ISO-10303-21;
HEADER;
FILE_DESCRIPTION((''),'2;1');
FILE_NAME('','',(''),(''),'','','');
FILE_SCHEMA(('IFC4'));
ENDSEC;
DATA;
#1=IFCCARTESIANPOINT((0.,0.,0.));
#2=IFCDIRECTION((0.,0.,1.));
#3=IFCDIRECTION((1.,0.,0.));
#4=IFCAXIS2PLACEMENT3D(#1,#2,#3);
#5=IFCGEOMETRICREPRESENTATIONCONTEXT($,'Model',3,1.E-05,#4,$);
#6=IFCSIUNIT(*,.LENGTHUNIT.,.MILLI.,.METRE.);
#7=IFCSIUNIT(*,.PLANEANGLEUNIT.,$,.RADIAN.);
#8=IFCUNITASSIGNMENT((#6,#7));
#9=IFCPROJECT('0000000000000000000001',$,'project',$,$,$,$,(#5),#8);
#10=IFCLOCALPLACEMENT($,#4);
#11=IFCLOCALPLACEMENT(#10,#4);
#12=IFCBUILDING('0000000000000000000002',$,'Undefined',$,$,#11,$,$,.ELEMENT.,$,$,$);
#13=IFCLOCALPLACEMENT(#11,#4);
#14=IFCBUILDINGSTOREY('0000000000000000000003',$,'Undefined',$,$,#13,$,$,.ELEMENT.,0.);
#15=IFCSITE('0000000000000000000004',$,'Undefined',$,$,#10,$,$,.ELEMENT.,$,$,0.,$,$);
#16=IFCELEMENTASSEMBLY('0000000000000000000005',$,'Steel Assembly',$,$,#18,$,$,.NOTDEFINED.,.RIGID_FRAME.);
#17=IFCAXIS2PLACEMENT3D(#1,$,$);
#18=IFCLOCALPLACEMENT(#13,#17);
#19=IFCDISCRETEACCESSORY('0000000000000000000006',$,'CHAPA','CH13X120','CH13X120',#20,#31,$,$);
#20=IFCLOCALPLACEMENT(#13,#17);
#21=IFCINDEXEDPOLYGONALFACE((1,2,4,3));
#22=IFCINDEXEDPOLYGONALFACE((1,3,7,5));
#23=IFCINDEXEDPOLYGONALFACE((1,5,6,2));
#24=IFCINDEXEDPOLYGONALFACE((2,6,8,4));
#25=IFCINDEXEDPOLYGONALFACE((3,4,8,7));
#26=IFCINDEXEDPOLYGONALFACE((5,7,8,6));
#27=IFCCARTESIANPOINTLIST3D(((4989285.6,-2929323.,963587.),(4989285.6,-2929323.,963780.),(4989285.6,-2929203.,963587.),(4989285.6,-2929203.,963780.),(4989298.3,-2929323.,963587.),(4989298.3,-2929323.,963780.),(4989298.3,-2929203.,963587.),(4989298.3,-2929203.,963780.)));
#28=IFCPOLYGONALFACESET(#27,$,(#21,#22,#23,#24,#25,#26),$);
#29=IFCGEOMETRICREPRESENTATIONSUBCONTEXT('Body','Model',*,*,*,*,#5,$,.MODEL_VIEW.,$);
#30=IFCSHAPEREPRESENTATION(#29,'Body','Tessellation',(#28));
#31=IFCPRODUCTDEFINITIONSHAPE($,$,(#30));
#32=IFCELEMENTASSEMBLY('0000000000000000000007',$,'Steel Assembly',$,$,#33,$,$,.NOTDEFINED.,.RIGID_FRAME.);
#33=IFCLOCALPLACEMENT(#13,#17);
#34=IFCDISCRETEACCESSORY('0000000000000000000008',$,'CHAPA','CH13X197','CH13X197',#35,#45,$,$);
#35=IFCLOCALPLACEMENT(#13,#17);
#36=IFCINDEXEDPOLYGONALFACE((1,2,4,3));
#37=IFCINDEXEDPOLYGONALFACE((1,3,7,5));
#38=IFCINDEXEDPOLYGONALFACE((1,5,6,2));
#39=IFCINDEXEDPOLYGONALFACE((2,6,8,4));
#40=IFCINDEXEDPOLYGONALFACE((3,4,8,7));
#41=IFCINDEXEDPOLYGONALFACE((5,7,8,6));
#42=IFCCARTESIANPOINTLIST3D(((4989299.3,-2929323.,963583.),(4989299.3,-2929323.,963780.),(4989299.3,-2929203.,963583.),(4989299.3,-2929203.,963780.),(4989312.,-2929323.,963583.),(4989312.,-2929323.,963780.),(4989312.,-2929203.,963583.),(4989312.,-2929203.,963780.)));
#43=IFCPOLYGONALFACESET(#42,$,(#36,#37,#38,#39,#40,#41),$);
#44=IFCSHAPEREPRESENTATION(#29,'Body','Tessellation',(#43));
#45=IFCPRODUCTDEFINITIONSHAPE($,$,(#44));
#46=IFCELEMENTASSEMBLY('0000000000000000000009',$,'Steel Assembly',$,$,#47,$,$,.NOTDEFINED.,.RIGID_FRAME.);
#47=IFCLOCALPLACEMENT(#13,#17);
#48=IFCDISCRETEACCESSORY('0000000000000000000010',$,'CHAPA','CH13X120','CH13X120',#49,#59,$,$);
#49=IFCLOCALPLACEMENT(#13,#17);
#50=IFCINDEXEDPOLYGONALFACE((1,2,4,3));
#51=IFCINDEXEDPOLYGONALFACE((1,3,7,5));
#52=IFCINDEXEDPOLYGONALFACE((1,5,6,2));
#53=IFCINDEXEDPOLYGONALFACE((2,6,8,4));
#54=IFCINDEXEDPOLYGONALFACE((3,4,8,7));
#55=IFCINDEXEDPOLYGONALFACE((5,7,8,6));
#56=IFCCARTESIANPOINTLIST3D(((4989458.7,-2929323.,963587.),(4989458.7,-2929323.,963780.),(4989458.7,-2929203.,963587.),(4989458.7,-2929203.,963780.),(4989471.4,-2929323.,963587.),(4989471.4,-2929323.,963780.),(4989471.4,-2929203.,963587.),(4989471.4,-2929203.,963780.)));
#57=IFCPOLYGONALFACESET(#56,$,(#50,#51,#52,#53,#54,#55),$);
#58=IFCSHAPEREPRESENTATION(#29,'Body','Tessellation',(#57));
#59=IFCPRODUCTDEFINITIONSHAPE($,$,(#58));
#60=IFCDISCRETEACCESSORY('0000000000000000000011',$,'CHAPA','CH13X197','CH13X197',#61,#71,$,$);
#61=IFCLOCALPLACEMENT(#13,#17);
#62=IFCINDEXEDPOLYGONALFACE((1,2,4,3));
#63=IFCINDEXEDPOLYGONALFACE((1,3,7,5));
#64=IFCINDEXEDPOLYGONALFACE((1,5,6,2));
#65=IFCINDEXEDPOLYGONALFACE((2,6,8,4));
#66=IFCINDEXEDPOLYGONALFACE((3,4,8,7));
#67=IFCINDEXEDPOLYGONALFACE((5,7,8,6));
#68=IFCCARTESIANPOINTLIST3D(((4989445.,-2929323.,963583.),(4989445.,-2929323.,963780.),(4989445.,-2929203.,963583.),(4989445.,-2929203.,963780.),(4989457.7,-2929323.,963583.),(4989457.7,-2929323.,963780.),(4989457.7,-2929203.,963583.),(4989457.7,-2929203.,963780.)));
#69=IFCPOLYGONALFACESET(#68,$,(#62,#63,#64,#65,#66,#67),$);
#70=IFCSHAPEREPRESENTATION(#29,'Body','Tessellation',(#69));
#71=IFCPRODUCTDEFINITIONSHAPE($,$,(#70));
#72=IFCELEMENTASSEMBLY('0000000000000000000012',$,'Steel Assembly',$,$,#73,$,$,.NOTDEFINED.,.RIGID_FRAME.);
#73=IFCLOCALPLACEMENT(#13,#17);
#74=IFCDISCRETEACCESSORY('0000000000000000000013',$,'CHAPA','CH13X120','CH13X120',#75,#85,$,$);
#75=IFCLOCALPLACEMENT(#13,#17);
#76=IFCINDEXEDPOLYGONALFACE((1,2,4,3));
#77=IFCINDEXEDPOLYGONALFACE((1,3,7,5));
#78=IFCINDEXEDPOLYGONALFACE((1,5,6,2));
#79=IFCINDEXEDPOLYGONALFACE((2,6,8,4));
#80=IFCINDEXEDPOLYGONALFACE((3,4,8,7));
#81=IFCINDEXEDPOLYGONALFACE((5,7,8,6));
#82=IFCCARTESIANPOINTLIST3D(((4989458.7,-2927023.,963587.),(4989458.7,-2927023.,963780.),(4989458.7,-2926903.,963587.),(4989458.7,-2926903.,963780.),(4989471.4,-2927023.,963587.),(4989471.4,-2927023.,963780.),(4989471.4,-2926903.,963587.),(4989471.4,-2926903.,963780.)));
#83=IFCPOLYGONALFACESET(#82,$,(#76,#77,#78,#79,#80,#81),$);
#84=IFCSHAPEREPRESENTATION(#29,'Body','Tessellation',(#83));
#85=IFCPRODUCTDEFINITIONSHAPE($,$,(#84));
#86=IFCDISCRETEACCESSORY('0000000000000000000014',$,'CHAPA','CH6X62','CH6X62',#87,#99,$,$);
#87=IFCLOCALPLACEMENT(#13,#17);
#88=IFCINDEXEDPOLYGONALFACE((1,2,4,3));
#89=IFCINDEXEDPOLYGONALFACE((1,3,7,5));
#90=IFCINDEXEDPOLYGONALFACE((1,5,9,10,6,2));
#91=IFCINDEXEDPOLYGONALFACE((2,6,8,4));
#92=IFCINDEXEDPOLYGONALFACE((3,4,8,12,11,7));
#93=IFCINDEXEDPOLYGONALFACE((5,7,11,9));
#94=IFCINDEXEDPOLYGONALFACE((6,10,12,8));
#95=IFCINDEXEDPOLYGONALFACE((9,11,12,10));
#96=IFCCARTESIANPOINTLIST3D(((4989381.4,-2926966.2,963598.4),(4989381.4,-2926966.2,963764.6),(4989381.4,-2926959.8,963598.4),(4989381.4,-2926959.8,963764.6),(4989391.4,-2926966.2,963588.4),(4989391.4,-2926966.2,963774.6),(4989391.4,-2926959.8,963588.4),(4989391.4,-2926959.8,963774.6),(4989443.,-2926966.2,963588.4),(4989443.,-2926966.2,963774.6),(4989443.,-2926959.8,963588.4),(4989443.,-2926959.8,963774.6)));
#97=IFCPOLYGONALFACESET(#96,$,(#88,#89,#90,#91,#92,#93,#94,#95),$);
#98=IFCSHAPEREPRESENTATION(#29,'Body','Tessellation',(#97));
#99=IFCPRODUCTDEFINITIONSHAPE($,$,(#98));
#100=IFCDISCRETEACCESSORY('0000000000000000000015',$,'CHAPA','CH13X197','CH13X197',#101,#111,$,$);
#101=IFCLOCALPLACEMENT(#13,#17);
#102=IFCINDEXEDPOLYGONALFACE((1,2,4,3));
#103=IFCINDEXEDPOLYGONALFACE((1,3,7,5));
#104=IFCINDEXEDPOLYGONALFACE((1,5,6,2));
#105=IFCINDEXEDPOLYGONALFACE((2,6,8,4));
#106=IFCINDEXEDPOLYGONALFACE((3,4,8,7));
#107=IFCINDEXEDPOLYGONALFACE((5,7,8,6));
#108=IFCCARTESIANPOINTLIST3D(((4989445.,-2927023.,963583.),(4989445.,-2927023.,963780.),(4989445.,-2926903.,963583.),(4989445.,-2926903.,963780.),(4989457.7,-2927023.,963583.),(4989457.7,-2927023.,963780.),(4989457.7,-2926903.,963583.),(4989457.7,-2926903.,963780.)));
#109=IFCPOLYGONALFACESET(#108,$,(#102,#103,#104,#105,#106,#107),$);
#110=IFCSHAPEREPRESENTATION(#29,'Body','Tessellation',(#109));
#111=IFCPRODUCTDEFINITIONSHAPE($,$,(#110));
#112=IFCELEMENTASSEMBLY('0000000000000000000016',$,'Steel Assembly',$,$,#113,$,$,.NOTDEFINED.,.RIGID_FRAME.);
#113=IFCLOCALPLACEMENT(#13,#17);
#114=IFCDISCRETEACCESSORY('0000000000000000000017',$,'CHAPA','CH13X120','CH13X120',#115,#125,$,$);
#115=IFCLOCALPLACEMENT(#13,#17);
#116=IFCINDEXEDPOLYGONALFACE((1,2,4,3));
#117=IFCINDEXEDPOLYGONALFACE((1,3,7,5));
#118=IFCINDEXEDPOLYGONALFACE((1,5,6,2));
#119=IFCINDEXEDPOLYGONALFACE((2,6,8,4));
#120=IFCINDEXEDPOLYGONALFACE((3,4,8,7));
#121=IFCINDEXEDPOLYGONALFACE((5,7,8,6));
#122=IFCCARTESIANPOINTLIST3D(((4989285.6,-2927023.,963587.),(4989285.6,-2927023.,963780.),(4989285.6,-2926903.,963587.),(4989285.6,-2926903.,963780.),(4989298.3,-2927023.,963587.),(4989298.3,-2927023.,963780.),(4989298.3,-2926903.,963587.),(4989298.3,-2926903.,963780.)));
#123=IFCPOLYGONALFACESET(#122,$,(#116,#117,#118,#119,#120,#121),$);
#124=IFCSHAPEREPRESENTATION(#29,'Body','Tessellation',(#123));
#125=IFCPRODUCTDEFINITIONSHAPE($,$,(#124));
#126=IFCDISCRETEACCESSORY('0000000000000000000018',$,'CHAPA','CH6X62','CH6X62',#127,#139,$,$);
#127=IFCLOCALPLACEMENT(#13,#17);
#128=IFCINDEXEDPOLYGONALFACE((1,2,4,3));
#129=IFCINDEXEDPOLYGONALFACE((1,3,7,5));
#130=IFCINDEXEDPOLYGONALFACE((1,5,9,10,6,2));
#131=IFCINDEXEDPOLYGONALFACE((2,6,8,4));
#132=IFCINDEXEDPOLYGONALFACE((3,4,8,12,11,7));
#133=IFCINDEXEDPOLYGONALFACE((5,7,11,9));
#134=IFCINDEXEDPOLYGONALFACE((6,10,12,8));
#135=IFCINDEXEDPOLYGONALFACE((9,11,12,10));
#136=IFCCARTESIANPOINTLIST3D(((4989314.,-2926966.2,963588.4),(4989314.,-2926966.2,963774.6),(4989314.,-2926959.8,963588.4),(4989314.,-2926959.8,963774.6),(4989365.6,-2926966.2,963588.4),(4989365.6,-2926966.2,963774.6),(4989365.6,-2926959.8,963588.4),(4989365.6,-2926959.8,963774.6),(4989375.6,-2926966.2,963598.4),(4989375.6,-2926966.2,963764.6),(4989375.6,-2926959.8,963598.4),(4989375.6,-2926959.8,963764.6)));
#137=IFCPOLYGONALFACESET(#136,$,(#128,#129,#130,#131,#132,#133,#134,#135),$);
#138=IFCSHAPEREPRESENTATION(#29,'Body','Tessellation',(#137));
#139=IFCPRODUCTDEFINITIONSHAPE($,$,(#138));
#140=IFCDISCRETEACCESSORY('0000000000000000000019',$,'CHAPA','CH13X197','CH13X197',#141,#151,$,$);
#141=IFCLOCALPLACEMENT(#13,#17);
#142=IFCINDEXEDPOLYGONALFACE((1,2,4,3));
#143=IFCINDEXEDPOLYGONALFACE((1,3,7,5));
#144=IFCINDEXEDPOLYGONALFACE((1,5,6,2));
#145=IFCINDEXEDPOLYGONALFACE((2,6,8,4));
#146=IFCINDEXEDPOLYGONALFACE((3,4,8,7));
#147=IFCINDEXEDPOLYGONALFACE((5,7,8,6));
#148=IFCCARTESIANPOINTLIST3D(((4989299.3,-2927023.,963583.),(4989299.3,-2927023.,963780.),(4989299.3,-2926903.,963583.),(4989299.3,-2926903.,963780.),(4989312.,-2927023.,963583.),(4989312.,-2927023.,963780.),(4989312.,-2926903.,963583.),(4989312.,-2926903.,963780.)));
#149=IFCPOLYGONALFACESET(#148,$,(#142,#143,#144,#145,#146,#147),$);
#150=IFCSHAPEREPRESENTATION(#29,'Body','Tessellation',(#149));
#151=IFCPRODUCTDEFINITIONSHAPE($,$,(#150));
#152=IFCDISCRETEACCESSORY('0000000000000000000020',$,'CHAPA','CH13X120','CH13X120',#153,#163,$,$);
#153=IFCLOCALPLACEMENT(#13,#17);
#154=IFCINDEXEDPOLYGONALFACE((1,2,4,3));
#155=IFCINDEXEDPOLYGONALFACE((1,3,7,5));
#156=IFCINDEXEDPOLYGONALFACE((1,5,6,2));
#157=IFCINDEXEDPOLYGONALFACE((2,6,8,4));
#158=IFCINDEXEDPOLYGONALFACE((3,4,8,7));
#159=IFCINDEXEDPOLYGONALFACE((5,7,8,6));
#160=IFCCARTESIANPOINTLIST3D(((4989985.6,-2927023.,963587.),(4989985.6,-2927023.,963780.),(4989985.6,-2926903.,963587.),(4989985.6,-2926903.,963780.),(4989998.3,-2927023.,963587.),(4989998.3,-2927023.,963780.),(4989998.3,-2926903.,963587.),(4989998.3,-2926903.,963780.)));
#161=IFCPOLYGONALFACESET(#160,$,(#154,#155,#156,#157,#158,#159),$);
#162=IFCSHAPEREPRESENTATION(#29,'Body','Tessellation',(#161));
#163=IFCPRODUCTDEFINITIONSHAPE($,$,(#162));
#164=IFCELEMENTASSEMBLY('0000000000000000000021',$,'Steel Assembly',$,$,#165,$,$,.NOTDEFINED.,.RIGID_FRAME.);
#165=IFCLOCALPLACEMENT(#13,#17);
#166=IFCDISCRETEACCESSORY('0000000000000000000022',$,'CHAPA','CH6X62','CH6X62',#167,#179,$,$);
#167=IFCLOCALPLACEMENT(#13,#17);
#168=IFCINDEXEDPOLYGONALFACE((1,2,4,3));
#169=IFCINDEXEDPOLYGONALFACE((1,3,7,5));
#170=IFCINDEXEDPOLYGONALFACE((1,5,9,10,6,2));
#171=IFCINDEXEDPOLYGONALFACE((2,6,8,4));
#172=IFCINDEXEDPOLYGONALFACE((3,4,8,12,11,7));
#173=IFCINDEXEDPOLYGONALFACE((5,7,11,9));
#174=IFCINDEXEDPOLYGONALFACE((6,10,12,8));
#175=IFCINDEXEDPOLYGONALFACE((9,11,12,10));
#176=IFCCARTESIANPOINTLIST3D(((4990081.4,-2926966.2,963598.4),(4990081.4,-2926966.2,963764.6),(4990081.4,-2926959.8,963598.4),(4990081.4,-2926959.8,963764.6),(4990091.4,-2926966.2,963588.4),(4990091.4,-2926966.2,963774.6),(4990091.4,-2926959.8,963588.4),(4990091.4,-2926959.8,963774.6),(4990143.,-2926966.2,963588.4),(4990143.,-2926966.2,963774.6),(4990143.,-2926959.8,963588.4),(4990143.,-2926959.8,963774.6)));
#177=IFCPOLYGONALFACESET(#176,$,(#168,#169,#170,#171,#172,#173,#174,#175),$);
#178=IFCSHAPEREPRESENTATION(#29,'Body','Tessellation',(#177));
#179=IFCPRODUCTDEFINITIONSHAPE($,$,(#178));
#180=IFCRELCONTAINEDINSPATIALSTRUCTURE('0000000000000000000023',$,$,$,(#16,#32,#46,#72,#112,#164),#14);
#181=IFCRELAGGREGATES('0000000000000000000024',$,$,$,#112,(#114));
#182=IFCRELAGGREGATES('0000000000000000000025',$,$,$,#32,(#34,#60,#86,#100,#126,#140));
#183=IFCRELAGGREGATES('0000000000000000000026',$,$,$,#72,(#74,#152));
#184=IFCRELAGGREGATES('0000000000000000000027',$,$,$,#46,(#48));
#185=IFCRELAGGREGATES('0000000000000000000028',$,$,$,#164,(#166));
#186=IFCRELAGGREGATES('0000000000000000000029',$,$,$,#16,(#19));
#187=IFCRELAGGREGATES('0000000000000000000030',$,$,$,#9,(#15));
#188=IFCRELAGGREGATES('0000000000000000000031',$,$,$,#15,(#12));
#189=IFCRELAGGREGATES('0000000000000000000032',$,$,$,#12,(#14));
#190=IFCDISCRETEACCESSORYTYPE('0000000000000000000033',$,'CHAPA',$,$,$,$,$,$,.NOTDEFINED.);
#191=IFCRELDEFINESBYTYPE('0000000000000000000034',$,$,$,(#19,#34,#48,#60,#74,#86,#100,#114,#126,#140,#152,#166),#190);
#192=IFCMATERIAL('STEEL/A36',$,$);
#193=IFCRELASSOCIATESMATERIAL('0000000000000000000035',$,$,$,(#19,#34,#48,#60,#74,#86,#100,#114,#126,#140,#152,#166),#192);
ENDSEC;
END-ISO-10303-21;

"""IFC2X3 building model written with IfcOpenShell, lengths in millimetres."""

from ifc_helpers import new_model, si_unit, frame, origin_with_axes, place, context, subcontext, project, spatial, polyline, outline, extrude, material, type_object, element, aggregate, save


model = new_model("IFC2X3")

# Units and contexts
model_context = context("Model", 3, precision=1e-05, world=origin_with_axes())
body_context = subcontext(model_context, "Body", "Model", "MODEL_VIEW")
ifc_project = project(units=[si_unit("LENGTHUNIT", "METRE", prefix="MILLI"), si_unit("PLANEANGLEUNIT", "RADIAN")], contexts=[model_context])

# Site, building, storey
site_placement = place(None, origin_with_axes())
site = spatial("IfcSite", under=ifc_project, at=site_placement, Name="Undefined", CompositionType="ELEMENT", RefElevation=0.0)
building_placement = place(site_placement, origin_with_axes())
building = spatial("IfcBuilding", under=site, at=building_placement, Name="Undefined", CompositionType="ELEMENT")
storey_placement = place(building_placement, origin_with_axes())
storey = spatial("IfcBuildingStorey", under=building, at=storey_placement, Name="Undefined", CompositionType="ELEMENT", Elevation=0.0)

# Element assemblies, discrete accessories
assembly_1_placement = place(storey_placement, origin_with_axes())
assembly_1 = element("IfcElementAssembly", 1, at=assembly_1_placement, inside=storey, Name="Steel Assembly", AssemblyPlace="NOTDEFINED", PredefinedType="RIGID_FRAME")
ifc_material_1 = material(Name="STEEL/A36")
discrete_accessory_type = type_object("IfcDiscreteAccessoryType", Name="CHAPA")
discrete_accessory_1_placement = place(assembly_1_placement, frame((4989291.9, -2929263.0, 963780.0), z_axis=(-1.0, 0.0, 0.0), x_axis=(0.0, 0.0, -1.0)))
discrete_accessory_1 = element("IfcDiscreteAccessory", 2, at=discrete_accessory_1_placement, type_object=discrete_accessory_type, material=ifc_material_1, Name="CHAPA", Description="CH13X120", ObjectType="CH13X120", context=body_context, shape_type="SweptSolid", body=[
    extrude(outline(polyline([(193.0, 60.0), (193.0, -60.0), (0.0, -60.0), (0.0, 60.0), (193.0, 60.0)])), frame((0.0, 0.0, -6.3), z_axis=(0.0, 0.0, 1.0), x_axis=(1.0, 0.0, 0.0)), (0.0, 0.0, 1.0), 12.7),
])
assembly_2_placement = place(storey_placement, origin_with_axes())
assembly_2 = element("IfcElementAssembly", 3, at=assembly_2_placement, inside=storey, Name="Steel Assembly", AssemblyPlace="NOTDEFINED", PredefinedType="RIGID_FRAME")
discrete_accessory_2_placement = place(assembly_2_placement, frame((4989305.6, -2929263.0, 963780.0), z_axis=(-1.0, 0.0, 0.0), x_axis=(0.0, 0.0, -1.0)))
discrete_accessory_2 = element("IfcDiscreteAccessory", 4, at=discrete_accessory_2_placement, type_object=discrete_accessory_type, material=ifc_material_1, Name="CHAPA", Description="CH13X197", ObjectType="CH13X197", context=body_context, shape_type="SweptSolid", body=[
    extrude(outline(polyline([(197.0, 60.0), (197.0, -60.0), (0.0, -60.0), (0.0, 60.0), (197.0, 60.0)])), frame((0.0, 0.0, -6.3), z_axis=(0.0, 0.0, 1.0), x_axis=(1.0, 0.0, 0.0)), (0.0, 0.0, 1.0), 12.7),
])
assembly_3_placement = place(storey_placement, origin_with_axes())
assembly_3 = element("IfcElementAssembly", 5, at=assembly_3_placement, inside=storey, Name="Steel Assembly", AssemblyPlace="NOTDEFINED", PredefinedType="RIGID_FRAME")
discrete_accessory_3_placement = place(assembly_3_placement, frame((4989465.0, -2929263.0, 963780.0), z_axis=(1.0, 0.0, 0.0), x_axis=(0.0, 0.0, -1.0)))
discrete_accessory_3 = element("IfcDiscreteAccessory", 6, at=discrete_accessory_3_placement, type_object=discrete_accessory_type, material=ifc_material_1, Name="CHAPA", Description="CH13X120", ObjectType="CH13X120", context=body_context, shape_type="SweptSolid", body=[
    extrude(outline(polyline([(193.0, -60.0), (0.0, -60.0), (0.0, 60.0), (193.0, 60.0), (193.0, -60.0)])), frame((0.0, 0.0, -6.3), z_axis=(0.0, 0.0, 1.0), x_axis=(1.0, 0.0, 0.0)), (0.0, 0.0, 1.0), 12.7),
])

# Discrete accessory
discrete_accessory_4_placement = place(assembly_2_placement, frame((4989451.3, -2929263.0, 963780.0), z_axis=(1.0, 0.0, 0.0), x_axis=(0.0, 0.0, -1.0)))
discrete_accessory_4 = element("IfcDiscreteAccessory", 7, at=discrete_accessory_4_placement, type_object=discrete_accessory_type, material=ifc_material_1, Name="CHAPA", Description="CH13X197", ObjectType="CH13X197", context=body_context, shape_type="SweptSolid", body=[
    extrude(outline(polyline([(197.0, -60.0), (0.0, -60.0), (0.0, 60.0), (197.0, 60.0), (197.0, -60.0)])), frame((0.0, 0.0, -6.3), z_axis=(0.0, 0.0, 1.0), x_axis=(1.0, 0.0, 0.0)), (0.0, 0.0, 1.0), 12.7),
])

# Element assembly, discrete accessory
assembly_4_placement = place(storey_placement, origin_with_axes())
assembly_4 = element("IfcElementAssembly", 8, at=assembly_4_placement, inside=storey, Name="Steel Assembly", AssemblyPlace="NOTDEFINED", PredefinedType="RIGID_FRAME")
discrete_accessory_5_placement = place(assembly_4_placement, frame((4989465.0, -2926963.0, 963780.0), z_axis=(1.0, 0.0, 0.0), x_axis=(0.0, 0.0, -1.0)))
discrete_accessory_5 = element("IfcDiscreteAccessory", 9, at=discrete_accessory_5_placement, type_object=discrete_accessory_type, material=ifc_material_1, Name="CHAPA", Description="CH13X120", ObjectType="CH13X120", context=body_context, shape_type="SweptSolid", body=[
    extrude(outline(polyline([(193.0, -60.0), (0.0, -60.0), (0.0, 60.0), (193.0, 60.0), (193.0, -60.0)])), frame((0.0, 0.0, -6.3), z_axis=(0.0, 0.0, 1.0), x_axis=(1.0, 0.0, 0.0)), (0.0, 0.0, 1.0), 12.7),
])

# Discrete accessories
discrete_accessory_6_placement = place(assembly_2_placement, frame((4989381.4, -2926963.0, 963774.6), z_axis=(0.0, 1.0, 0.0), x_axis=(1.0, 0.0, 0.0)))
discrete_accessory_6 = element("IfcDiscreteAccessory", 10, at=discrete_accessory_6_placement, type_object=discrete_accessory_type, material=ifc_material_1, Name="CHAPA", Description="CH6X62", ObjectType="CH6X62", context=body_context, shape_type="SweptSolid", body=[
    extrude(outline(polyline([(0.0, 10.0), (10.0, 0.0), (61.6, 0.0), (61.6, 186.2), (10.0, 186.2), (0.0, 176.2), (0.0, 10.0)])), frame((0.0, 0.0, -3.2), z_axis=(0.0, 0.0, 1.0), x_axis=(1.0, 0.0, 0.0)), (0.0, 0.0, 1.0), 6.4),
])
discrete_accessory_7_placement = place(assembly_2_placement, frame((4989451.3, -2926963.0, 963780.0), z_axis=(1.0, 0.0, 0.0), x_axis=(0.0, 0.0, -1.0)))
discrete_accessory_7 = element("IfcDiscreteAccessory", 11, at=discrete_accessory_7_placement, type_object=discrete_accessory_type, material=ifc_material_1, Name="CHAPA", Description="CH13X197", ObjectType="CH13X197", context=body_context, shape_type="SweptSolid", body=[
    extrude(outline(polyline([(197.0, -60.0), (0.0, -60.0), (0.0, 60.0), (197.0, 60.0), (197.0, -60.0)])), frame((0.0, 0.0, -6.3), z_axis=(0.0, 0.0, 1.0), x_axis=(1.0, 0.0, 0.0)), (0.0, 0.0, 1.0), 12.7),
])

# Element assembly, discrete accessory
assembly_5_placement = place(storey_placement, origin_with_axes())
assembly_5 = element("IfcElementAssembly", 12, at=assembly_5_placement, inside=storey, Name="Steel Assembly", AssemblyPlace="NOTDEFINED", PredefinedType="RIGID_FRAME")
discrete_accessory_8_placement = place(assembly_5_placement, frame((4989291.9, -2926963.0, 963780.0), z_axis=(-1.0, 0.0, 0.0), x_axis=(0.0, 0.0, -1.0)))
discrete_accessory_8 = element("IfcDiscreteAccessory", 13, at=discrete_accessory_8_placement, type_object=discrete_accessory_type, material=ifc_material_1, Name="CHAPA", Description="CH13X120", ObjectType="CH13X120", context=body_context, shape_type="SweptSolid", body=[
    extrude(outline(polyline([(193.0, 60.0), (193.0, -60.0), (0.0, -60.0), (0.0, 60.0), (193.0, 60.0)])), frame((0.0, 0.0, -6.3), z_axis=(0.0, 0.0, 1.0), x_axis=(1.0, 0.0, 0.0)), (0.0, 0.0, 1.0), 12.7),
])
aggregate(assembly_5, [discrete_accessory_8])

# Discrete accessories
discrete_accessory_9_placement = place(assembly_2_placement, frame((4989375.6, -2926963.0, 963774.6), z_axis=(0.0, -1.0, 0.0), x_axis=(-1.0, 0.0, 0.0)))
discrete_accessory_9 = element("IfcDiscreteAccessory", 14, at=discrete_accessory_9_placement, type_object=discrete_accessory_type, material=ifc_material_1, Name="CHAPA", Description="CH6X62", ObjectType="CH6X62", context=body_context, shape_type="SweptSolid", body=[
    extrude(outline(polyline([(0.0, 10.0), (10.0, 0.0), (61.6, 0.0), (61.6, 186.2), (10.0, 186.2), (0.0, 176.2), (0.0, 10.0)])), frame((0.0, 0.0, -3.2), z_axis=(0.0, 0.0, 1.0), x_axis=(1.0, 0.0, 0.0)), (0.0, 0.0, 1.0), 6.4),
])
discrete_accessory_10_placement = place(assembly_2_placement, frame((4989305.6, -2926963.0, 963780.0), z_axis=(-1.0, 0.0, 0.0), x_axis=(0.0, 0.0, -1.0)))
discrete_accessory_10 = element("IfcDiscreteAccessory", 15, at=discrete_accessory_10_placement, type_object=discrete_accessory_type, material=ifc_material_1, Name="CHAPA", Description="CH13X197", ObjectType="CH13X197", context=body_context, shape_type="SweptSolid", body=[
    extrude(outline(polyline([(197.0, 60.0), (197.0, -60.0), (0.0, -60.0), (0.0, 60.0), (197.0, 60.0)])), frame((0.0, 0.0, -6.3), z_axis=(0.0, 0.0, 1.0), x_axis=(1.0, 0.0, 0.0)), (0.0, 0.0, 1.0), 12.7),
])
aggregate(assembly_2, [discrete_accessory_2, discrete_accessory_4, discrete_accessory_6, discrete_accessory_7, discrete_accessory_9, discrete_accessory_10])
discrete_accessory_11_placement = place(assembly_4_placement, frame((4989991.9, -2926963.0, 963780.0), z_axis=(-1.0, 0.0, 0.0), x_axis=(0.0, 0.0, -1.0)))
discrete_accessory_11 = element("IfcDiscreteAccessory", 16, at=discrete_accessory_11_placement, type_object=discrete_accessory_type, material=ifc_material_1, Name="CHAPA", Description="CH13X120", ObjectType="CH13X120", context=body_context, shape_type="SweptSolid", body=[
    extrude(outline(polyline([(193.0, 60.0), (193.0, -60.0), (0.0, -60.0), (0.0, 60.0), (193.0, 60.0)])), frame((0.0, 0.0, -6.3), z_axis=(0.0, 0.0, 1.0), x_axis=(1.0, 0.0, 0.0)), (0.0, 0.0, 1.0), 12.7),
])
aggregate(assembly_4, [discrete_accessory_5, discrete_accessory_11])

# Element assembly, discrete accessory
assembly_6_placement = place(storey_placement, origin_with_axes())
assembly_6 = element("IfcElementAssembly", 17, at=assembly_6_placement, inside=storey, Name="Steel Assembly", AssemblyPlace="NOTDEFINED", PredefinedType="RIGID_FRAME")
discrete_accessory_12_placement = place(assembly_6_placement, frame((4990081.4, -2926963.0, 963774.6), z_axis=(0.0, 1.0, 0.0), x_axis=(1.0, 0.0, 0.0)))
discrete_accessory_12 = element("IfcDiscreteAccessory", 18, at=discrete_accessory_12_placement, type_object=discrete_accessory_type, material=ifc_material_1, Name="CHAPA", Description="CH6X62", ObjectType="CH6X62", context=body_context, shape_type="SweptSolid", body=[
    extrude(outline(polyline([(0.0, 10.0), (10.0, 0.0), (61.6, 0.0), (61.6, 186.2), (10.0, 186.2), (0.0, 176.2), (0.0, 10.0)])), frame((0.0, 0.0, -3.2), z_axis=(0.0, 0.0, 1.0), x_axis=(1.0, 0.0, 0.0)), (0.0, 0.0, 1.0), 6.4),
])

aggregate(assembly_3, [discrete_accessory_3])
aggregate(assembly_6, [discrete_accessory_12])
aggregate(assembly_1, [discrete_accessory_1])

save(model, "model.ifc")
